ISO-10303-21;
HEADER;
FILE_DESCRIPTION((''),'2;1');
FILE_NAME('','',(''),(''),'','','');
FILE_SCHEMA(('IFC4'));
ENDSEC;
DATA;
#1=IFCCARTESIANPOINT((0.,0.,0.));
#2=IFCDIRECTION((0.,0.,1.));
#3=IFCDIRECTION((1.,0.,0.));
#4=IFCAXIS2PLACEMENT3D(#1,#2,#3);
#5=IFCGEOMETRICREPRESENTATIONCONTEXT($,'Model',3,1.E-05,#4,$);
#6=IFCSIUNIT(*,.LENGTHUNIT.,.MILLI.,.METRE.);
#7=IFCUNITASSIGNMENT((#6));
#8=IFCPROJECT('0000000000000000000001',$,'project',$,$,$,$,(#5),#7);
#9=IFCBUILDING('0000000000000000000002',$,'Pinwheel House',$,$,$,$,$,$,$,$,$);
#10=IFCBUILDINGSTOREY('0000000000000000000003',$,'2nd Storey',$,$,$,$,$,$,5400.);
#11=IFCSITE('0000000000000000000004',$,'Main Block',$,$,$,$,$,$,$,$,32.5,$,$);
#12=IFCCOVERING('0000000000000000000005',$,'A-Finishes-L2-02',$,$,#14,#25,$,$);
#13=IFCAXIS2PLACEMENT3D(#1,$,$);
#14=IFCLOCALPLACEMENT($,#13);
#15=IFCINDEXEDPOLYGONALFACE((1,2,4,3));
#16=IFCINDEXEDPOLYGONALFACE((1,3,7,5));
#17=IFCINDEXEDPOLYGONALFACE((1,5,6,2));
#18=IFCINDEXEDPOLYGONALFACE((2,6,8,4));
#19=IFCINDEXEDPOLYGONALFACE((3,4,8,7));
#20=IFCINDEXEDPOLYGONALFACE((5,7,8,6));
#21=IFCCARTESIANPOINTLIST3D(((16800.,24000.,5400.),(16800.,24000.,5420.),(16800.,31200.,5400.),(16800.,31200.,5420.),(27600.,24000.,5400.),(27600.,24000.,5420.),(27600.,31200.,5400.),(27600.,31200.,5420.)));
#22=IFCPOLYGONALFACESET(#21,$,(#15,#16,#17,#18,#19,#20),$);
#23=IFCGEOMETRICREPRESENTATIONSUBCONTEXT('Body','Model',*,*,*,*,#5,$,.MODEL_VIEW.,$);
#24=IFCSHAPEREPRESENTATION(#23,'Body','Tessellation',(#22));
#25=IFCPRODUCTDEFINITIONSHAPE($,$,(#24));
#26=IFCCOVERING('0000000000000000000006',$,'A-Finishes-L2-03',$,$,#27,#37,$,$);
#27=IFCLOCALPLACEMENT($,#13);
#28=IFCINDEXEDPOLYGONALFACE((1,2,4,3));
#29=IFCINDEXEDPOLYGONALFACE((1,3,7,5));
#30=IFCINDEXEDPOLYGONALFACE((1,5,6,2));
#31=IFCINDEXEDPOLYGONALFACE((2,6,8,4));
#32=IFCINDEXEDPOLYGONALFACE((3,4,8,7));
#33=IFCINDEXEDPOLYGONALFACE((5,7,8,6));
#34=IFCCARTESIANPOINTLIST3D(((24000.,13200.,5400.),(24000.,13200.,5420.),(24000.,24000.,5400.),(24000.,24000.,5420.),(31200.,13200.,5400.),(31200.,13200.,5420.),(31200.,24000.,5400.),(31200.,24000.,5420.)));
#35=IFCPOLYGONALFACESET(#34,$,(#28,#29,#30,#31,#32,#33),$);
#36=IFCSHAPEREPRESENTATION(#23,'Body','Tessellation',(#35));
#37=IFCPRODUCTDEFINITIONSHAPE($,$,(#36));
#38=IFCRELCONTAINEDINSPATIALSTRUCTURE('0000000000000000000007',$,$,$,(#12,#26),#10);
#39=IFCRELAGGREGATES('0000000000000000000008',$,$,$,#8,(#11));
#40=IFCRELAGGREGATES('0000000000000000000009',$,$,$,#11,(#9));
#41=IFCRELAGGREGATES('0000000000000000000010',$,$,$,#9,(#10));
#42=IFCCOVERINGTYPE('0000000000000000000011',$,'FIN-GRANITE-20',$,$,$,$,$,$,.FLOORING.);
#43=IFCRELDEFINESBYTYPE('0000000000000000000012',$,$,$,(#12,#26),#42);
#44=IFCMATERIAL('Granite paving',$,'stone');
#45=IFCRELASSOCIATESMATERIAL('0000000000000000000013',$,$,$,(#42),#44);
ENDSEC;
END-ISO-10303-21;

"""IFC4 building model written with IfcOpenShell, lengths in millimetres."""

from ifc_helpers import new_model, si_unit, frame, origin_with_axes, place, context, subcontext, project, spatial, indexed_curve, outline, extrude, material, type_object, element, save


model = new_model("IFC4")

# Units and contexts
model_context = context("Model", 3, precision=1e-05, world=origin_with_axes())
body_context = subcontext(model_context, "Body", "Model", "MODEL_VIEW")
ifc_project = project(units=[si_unit("LENGTHUNIT", "METRE", prefix="MILLI")], contexts=[model_context])

# Site, building, storey
site = spatial("IfcSite", under=ifc_project, Name="Main Block", RefElevation=32.5)
building = spatial("IfcBuilding", under=site, Name="Pinwheel House")
storey = spatial("IfcBuildingStorey", under=building, Name="2nd Storey", Elevation=5400.0)

# Coverings
ifc_material_1 = material(Name="Granite paving", Category="stone")
covering_type = type_object("IfcCoveringType", Name="FIN-GRANITE-20", PredefinedType="FLOORING", material=ifc_material_1)
covering_1_placement = place(None, frame((0.0, 0.0, 5400.0), z_axis=(0.0, 0.0, 1.0), x_axis=(1.0, 0.0, 0.0)))
element("IfcCovering", 1, at=covering_1_placement, inside=storey, type_object=covering_type, Name="A-Finishes-L2-02", context=body_context, shape_type="SweptSolid", body=[
    extrude(outline(indexed_curve([(16800.0, 24000.0), (27600.0, 24000.0), (27600.0, 31200.0), (16800.0, 31200.0)])), None, (0.0, 0.0, 1.0), 20.0),
])
covering_2_placement = place(None, frame((0.0, 0.0, 5400.0), z_axis=(0.0, 0.0, 1.0), x_axis=(1.0, 0.0, 0.0)))
element("IfcCovering", 2, at=covering_2_placement, inside=storey, type_object=covering_type, Name="A-Finishes-L2-03", context=body_context, shape_type="SweptSolid", body=[
    extrude(outline(indexed_curve([(24000.0, 13200.0), (31200.0, 13200.0), (31200.0, 24000.0), (24000.0, 24000.0)])), None, (0.0, 0.0, 1.0), 20.0),
])

save(model, "model.ifc")
